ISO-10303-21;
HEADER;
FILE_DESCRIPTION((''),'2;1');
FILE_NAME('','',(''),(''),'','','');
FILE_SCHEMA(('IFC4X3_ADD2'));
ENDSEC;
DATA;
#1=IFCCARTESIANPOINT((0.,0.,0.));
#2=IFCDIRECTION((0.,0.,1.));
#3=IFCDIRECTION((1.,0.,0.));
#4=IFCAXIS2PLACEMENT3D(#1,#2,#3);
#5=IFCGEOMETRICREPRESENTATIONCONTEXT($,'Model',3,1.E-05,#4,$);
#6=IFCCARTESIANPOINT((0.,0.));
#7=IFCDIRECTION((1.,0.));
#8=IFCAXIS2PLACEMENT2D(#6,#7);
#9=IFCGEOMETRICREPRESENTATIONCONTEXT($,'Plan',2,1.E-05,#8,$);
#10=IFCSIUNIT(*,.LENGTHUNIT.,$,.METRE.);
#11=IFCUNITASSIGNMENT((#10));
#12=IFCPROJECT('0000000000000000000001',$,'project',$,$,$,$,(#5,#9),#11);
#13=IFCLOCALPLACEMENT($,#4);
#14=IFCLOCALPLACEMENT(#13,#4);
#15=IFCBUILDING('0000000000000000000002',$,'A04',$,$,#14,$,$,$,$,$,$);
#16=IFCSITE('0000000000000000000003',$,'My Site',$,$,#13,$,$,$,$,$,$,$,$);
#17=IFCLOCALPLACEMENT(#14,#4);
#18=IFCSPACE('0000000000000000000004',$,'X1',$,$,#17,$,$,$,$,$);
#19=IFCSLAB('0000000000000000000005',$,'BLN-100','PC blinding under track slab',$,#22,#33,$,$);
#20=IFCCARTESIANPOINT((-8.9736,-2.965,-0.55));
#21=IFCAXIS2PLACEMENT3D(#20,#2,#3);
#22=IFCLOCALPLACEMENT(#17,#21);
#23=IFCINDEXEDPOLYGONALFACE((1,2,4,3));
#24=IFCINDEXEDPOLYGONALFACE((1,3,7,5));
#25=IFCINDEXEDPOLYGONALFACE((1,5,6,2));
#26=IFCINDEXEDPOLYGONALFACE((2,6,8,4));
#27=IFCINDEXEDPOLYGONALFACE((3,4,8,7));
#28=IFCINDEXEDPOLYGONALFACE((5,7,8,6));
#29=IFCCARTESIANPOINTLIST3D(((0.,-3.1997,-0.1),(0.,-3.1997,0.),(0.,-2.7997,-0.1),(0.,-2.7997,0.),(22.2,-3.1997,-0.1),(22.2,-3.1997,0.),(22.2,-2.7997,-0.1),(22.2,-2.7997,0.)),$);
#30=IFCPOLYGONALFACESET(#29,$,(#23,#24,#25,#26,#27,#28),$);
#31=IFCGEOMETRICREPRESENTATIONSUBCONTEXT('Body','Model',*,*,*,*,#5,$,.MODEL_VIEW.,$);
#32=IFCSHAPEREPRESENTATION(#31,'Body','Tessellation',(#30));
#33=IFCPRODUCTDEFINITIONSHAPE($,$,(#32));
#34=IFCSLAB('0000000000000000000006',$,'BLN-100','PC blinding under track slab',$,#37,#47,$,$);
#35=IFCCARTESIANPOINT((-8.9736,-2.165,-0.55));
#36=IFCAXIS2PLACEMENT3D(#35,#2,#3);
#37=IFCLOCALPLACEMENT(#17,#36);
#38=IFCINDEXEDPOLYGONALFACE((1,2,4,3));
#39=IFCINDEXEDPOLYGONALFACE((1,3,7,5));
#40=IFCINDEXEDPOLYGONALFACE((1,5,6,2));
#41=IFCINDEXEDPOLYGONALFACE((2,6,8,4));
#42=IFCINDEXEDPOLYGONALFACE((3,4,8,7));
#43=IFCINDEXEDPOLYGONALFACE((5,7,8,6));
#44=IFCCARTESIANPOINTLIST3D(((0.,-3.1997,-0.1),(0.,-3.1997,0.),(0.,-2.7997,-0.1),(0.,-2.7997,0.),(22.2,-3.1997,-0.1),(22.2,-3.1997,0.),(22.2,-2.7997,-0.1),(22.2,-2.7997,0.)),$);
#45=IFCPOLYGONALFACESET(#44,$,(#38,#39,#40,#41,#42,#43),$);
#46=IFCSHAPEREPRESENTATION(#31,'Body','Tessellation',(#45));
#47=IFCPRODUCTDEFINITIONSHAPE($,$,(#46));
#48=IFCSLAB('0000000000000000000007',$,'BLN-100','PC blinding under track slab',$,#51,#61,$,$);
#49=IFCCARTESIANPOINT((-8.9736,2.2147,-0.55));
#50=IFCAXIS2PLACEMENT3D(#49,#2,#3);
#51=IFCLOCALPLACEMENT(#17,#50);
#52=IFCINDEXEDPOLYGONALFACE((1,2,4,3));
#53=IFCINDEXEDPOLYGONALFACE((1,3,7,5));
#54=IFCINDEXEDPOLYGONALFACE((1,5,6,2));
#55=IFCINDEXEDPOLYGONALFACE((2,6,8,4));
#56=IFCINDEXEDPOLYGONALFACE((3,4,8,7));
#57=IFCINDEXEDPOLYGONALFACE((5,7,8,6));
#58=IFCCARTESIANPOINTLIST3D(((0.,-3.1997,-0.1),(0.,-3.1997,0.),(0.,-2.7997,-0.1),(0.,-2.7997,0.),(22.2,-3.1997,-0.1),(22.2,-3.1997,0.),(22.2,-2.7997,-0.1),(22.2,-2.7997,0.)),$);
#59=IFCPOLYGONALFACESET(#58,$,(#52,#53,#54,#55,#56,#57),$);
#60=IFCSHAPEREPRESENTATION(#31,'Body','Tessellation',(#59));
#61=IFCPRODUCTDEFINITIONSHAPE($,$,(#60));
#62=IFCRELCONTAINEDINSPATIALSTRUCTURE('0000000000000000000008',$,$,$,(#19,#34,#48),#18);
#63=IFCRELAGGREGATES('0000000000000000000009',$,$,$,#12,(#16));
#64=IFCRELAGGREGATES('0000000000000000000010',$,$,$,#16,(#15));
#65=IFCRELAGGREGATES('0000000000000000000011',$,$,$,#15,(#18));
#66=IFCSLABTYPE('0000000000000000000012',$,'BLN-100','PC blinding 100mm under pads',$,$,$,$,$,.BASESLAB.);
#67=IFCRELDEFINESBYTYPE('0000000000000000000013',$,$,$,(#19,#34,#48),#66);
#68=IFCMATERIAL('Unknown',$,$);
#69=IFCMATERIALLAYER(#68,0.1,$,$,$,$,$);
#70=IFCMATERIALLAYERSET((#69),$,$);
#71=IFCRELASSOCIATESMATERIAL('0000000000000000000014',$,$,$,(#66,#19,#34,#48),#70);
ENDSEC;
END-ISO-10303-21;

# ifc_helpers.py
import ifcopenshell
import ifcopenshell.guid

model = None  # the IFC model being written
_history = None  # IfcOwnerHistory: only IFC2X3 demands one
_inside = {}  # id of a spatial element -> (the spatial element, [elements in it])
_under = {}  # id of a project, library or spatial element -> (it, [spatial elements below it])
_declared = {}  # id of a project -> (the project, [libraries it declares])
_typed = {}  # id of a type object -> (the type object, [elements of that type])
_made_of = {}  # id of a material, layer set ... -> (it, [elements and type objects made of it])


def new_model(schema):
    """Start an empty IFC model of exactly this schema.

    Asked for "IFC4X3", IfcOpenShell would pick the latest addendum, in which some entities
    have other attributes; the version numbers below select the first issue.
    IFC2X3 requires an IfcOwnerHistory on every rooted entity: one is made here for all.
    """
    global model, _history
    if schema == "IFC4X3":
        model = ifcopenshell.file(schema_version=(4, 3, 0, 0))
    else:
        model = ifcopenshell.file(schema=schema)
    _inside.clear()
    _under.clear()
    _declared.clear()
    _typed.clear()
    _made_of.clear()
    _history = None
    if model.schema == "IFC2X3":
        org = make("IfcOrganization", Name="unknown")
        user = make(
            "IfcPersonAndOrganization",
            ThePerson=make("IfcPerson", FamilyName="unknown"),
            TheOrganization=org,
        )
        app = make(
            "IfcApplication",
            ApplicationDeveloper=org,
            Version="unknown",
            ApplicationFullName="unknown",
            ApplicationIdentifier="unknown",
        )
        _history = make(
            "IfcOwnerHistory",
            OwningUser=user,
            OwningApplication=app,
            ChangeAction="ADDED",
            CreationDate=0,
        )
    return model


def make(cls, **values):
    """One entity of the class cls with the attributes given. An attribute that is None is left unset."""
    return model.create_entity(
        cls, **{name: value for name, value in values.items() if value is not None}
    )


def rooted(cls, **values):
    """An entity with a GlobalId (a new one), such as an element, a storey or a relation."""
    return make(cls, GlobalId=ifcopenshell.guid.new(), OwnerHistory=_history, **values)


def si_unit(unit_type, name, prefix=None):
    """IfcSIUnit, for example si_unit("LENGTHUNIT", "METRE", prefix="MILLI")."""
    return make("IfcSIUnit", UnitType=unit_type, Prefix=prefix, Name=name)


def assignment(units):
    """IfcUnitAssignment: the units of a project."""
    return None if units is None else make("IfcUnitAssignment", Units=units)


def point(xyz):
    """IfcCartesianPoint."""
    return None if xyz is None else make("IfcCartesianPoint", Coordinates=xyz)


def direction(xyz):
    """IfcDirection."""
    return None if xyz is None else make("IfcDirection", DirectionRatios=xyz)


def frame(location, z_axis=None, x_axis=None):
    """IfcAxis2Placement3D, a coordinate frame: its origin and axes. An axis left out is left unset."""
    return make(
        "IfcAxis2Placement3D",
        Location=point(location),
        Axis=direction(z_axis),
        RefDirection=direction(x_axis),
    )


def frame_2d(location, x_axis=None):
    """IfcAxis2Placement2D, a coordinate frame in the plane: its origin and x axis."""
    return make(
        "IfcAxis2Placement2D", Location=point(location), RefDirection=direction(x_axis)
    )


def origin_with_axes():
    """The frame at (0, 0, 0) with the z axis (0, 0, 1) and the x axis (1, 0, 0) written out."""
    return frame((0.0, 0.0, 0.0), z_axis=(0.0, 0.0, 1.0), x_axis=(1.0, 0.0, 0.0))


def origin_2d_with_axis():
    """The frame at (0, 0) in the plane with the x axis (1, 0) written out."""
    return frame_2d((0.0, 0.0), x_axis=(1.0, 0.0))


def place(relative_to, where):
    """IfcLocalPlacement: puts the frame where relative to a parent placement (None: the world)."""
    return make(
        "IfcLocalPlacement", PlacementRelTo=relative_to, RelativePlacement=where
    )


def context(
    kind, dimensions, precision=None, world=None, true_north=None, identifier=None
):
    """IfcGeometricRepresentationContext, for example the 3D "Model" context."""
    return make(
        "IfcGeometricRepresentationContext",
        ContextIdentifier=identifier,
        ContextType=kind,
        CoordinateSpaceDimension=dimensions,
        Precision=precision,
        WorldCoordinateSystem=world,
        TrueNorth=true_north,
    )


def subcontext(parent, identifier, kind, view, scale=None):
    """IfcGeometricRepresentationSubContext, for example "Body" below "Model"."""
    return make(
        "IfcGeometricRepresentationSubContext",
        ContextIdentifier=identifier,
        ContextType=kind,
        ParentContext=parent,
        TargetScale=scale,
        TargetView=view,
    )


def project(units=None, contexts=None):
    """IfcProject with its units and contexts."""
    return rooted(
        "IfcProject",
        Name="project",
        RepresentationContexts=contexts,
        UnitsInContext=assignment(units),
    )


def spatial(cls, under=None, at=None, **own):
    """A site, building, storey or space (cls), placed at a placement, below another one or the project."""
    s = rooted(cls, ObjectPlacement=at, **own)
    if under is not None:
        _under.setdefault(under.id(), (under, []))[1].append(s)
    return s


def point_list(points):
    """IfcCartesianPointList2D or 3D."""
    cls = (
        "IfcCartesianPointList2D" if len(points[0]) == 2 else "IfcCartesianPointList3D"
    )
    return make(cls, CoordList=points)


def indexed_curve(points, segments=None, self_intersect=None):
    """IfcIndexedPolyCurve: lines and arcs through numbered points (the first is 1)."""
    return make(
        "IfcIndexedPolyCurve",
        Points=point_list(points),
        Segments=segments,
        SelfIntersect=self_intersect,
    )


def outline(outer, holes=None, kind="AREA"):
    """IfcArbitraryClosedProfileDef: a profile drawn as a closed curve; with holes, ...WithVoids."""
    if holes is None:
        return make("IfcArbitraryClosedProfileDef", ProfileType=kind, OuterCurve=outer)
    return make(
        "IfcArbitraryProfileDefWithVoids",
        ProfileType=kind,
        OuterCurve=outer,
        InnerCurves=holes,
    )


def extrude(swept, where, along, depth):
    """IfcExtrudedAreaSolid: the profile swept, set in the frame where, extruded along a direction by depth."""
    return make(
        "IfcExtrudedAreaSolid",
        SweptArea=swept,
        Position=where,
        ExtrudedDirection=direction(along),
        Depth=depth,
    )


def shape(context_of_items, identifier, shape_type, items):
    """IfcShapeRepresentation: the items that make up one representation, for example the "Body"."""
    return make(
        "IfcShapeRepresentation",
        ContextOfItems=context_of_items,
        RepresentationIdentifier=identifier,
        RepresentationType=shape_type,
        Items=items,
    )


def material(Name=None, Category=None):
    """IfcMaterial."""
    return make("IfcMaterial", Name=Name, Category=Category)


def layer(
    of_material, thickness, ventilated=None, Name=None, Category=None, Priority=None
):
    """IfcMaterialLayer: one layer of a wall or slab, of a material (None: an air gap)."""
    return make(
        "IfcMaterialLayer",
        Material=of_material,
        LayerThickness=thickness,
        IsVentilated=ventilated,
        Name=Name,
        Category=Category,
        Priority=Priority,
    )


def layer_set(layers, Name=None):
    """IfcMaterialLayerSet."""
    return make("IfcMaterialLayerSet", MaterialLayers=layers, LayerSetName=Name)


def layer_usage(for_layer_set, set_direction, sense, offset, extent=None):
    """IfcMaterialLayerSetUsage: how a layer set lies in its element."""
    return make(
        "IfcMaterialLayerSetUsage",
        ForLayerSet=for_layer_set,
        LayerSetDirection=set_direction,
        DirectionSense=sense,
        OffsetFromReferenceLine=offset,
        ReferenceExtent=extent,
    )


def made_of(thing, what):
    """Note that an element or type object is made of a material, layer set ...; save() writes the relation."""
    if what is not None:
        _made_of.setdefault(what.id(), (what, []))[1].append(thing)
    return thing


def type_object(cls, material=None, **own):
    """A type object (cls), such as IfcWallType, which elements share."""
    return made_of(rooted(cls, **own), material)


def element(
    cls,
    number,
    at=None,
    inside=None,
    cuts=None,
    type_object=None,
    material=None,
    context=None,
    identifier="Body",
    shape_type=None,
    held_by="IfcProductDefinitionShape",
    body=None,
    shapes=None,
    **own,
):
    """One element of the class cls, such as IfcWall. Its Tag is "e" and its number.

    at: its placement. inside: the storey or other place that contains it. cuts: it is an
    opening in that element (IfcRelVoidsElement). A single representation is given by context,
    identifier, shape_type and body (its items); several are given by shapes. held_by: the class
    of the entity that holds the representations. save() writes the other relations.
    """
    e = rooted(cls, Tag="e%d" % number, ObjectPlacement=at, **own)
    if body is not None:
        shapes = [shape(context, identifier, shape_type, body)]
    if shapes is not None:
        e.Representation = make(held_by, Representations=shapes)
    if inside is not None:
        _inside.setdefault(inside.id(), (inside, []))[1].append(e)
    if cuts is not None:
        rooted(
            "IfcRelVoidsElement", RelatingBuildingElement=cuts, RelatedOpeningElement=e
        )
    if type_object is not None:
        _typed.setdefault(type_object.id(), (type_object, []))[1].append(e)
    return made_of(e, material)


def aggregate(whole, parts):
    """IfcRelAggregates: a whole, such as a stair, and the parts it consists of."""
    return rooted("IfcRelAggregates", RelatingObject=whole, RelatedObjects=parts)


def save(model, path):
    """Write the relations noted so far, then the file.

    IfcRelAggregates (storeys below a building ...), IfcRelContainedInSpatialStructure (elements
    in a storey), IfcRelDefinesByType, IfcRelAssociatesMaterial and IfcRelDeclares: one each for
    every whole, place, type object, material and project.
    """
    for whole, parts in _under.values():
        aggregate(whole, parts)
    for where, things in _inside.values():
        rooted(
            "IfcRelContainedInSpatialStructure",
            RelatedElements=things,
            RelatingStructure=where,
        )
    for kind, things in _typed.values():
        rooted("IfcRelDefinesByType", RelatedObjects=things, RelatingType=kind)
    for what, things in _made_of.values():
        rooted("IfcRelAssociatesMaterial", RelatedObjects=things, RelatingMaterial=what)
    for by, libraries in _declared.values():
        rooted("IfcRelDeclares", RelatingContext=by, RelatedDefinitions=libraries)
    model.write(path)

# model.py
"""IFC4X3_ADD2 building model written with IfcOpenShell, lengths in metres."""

from ifc_helpers import new_model, si_unit, frame, origin_with_axes, origin_2d_with_axis, place, context, subcontext, project, spatial, indexed_curve, outline, extrude, material, layer, layer_set, layer_usage, type_object, element, save


model = new_model("IFC4X3_ADD2")

# Units and contexts
model_context = context("Model", 3, precision=1e-05, world=origin_with_axes())
plan_context = context("Plan", 2, precision=1e-05, world=origin_2d_with_axis())
body_context = subcontext(model_context, "Body", "Model", "MODEL_VIEW")
ifc_project = project(units=[si_unit("LENGTHUNIT", "METRE")], contexts=[model_context, plan_context])

# Site, building, space
site_placement = place(None, origin_with_axes())
site = spatial("IfcSite", under=ifc_project, at=site_placement, Name="My Site")
building_placement = place(site_placement, origin_with_axes())
building = spatial("IfcBuilding", under=site, at=building_placement, Name="A04")
space_placement = place(building_placement, origin_with_axes())
space = spatial("IfcSpace", under=building, at=space_placement, Name="X1")

# Slabs
ifc_material_1 = material(Name="Unknown")
ifc_layer_1 = layer(ifc_material_1, 0.1)
ifc_layer_set_1 = layer_set([ifc_layer_1])
slab_type_1 = type_object("IfcSlabType", Name="BLN-100", Description="PC blinding 100mm under pads", PredefinedType="BASESLAB", material=ifc_layer_set_1)
ifc_layer_usage_1 = layer_usage(ifc_layer_set_1, "AXIS3", "POSITIVE", -0.1)
slab_1_placement = place(space_placement, frame((-8.9736, -2.965, -0.55), z_axis=(0.0, 0.0, 1.0), x_axis=(1.0, 0.0, 0.0)))
element("IfcSlab", 1, at=slab_1_placement, inside=space, type_object=slab_type_1, material=ifc_layer_usage_1, Name="BLN-100", Description="PC blinding under track slab", context=body_context, shape_type="SweptSolid", body=[
    extrude(outline(indexed_curve([(0.0, -3.1997), (22.2, -3.1997), (22.2, -2.7997), (0.0, -2.7997), (0.0, -3.1997)])), frame((0.0, 0.0, -0.1), z_axis=(0.0, 0.0, 1.0), x_axis=(1.0, 0.0, 0.0)), (0.0, 0.0, 1.0), 0.1),
])
ifc_layer_usage_2 = layer_usage(ifc_layer_set_1, "AXIS3", "POSITIVE", -0.1)
slab_2_placement = place(space_placement, frame((-8.9736, -2.165, -0.55), z_axis=(0.0, 0.0, 1.0), x_axis=(1.0, 0.0, 0.0)))
element("IfcSlab", 2, at=slab_2_placement, inside=space, type_object=slab_type_1, material=ifc_layer_usage_2, Name="BLN-100", Description="PC blinding under track slab", context=body_context, shape_type="SweptSolid", body=[
    extrude(outline(indexed_curve([(0.0, -3.1997), (22.2, -3.1997), (22.2, -2.7997), (0.0, -2.7997), (0.0, -3.1997)])), frame((0.0, 0.0, -0.1), z_axis=(0.0, 0.0, 1.0), x_axis=(1.0, 0.0, 0.0)), (0.0, 0.0, 1.0), 0.1),
])
ifc_layer_usage_3 = layer_usage(ifc_layer_set_1, "AXIS3", "POSITIVE", -0.1)
slab_3_placement = place(space_placement, frame((-8.9736, 2.2147, -0.55), z_axis=(0.0, 0.0, 1.0), x_axis=(1.0, 0.0, 0.0)))
element("IfcSlab", 3, at=slab_3_placement, inside=space, type_object=slab_type_1, material=ifc_layer_usage_3, Name="BLN-100", Description="PC blinding under track slab", context=body_context, shape_type="SweptSolid", body=[
    extrude(outline(indexed_curve([(0.0, -3.1997), (22.2, -3.1997), (22.2, -2.7997), (0.0, -2.7997), (0.0, -3.1997)])), frame((0.0, 0.0, -0.1), z_axis=(0.0, 0.0, 1.0), x_axis=(1.0, 0.0, 0.0)), (0.0, 0.0, 1.0), 0.1),
])

save(model, "model.ifc")
